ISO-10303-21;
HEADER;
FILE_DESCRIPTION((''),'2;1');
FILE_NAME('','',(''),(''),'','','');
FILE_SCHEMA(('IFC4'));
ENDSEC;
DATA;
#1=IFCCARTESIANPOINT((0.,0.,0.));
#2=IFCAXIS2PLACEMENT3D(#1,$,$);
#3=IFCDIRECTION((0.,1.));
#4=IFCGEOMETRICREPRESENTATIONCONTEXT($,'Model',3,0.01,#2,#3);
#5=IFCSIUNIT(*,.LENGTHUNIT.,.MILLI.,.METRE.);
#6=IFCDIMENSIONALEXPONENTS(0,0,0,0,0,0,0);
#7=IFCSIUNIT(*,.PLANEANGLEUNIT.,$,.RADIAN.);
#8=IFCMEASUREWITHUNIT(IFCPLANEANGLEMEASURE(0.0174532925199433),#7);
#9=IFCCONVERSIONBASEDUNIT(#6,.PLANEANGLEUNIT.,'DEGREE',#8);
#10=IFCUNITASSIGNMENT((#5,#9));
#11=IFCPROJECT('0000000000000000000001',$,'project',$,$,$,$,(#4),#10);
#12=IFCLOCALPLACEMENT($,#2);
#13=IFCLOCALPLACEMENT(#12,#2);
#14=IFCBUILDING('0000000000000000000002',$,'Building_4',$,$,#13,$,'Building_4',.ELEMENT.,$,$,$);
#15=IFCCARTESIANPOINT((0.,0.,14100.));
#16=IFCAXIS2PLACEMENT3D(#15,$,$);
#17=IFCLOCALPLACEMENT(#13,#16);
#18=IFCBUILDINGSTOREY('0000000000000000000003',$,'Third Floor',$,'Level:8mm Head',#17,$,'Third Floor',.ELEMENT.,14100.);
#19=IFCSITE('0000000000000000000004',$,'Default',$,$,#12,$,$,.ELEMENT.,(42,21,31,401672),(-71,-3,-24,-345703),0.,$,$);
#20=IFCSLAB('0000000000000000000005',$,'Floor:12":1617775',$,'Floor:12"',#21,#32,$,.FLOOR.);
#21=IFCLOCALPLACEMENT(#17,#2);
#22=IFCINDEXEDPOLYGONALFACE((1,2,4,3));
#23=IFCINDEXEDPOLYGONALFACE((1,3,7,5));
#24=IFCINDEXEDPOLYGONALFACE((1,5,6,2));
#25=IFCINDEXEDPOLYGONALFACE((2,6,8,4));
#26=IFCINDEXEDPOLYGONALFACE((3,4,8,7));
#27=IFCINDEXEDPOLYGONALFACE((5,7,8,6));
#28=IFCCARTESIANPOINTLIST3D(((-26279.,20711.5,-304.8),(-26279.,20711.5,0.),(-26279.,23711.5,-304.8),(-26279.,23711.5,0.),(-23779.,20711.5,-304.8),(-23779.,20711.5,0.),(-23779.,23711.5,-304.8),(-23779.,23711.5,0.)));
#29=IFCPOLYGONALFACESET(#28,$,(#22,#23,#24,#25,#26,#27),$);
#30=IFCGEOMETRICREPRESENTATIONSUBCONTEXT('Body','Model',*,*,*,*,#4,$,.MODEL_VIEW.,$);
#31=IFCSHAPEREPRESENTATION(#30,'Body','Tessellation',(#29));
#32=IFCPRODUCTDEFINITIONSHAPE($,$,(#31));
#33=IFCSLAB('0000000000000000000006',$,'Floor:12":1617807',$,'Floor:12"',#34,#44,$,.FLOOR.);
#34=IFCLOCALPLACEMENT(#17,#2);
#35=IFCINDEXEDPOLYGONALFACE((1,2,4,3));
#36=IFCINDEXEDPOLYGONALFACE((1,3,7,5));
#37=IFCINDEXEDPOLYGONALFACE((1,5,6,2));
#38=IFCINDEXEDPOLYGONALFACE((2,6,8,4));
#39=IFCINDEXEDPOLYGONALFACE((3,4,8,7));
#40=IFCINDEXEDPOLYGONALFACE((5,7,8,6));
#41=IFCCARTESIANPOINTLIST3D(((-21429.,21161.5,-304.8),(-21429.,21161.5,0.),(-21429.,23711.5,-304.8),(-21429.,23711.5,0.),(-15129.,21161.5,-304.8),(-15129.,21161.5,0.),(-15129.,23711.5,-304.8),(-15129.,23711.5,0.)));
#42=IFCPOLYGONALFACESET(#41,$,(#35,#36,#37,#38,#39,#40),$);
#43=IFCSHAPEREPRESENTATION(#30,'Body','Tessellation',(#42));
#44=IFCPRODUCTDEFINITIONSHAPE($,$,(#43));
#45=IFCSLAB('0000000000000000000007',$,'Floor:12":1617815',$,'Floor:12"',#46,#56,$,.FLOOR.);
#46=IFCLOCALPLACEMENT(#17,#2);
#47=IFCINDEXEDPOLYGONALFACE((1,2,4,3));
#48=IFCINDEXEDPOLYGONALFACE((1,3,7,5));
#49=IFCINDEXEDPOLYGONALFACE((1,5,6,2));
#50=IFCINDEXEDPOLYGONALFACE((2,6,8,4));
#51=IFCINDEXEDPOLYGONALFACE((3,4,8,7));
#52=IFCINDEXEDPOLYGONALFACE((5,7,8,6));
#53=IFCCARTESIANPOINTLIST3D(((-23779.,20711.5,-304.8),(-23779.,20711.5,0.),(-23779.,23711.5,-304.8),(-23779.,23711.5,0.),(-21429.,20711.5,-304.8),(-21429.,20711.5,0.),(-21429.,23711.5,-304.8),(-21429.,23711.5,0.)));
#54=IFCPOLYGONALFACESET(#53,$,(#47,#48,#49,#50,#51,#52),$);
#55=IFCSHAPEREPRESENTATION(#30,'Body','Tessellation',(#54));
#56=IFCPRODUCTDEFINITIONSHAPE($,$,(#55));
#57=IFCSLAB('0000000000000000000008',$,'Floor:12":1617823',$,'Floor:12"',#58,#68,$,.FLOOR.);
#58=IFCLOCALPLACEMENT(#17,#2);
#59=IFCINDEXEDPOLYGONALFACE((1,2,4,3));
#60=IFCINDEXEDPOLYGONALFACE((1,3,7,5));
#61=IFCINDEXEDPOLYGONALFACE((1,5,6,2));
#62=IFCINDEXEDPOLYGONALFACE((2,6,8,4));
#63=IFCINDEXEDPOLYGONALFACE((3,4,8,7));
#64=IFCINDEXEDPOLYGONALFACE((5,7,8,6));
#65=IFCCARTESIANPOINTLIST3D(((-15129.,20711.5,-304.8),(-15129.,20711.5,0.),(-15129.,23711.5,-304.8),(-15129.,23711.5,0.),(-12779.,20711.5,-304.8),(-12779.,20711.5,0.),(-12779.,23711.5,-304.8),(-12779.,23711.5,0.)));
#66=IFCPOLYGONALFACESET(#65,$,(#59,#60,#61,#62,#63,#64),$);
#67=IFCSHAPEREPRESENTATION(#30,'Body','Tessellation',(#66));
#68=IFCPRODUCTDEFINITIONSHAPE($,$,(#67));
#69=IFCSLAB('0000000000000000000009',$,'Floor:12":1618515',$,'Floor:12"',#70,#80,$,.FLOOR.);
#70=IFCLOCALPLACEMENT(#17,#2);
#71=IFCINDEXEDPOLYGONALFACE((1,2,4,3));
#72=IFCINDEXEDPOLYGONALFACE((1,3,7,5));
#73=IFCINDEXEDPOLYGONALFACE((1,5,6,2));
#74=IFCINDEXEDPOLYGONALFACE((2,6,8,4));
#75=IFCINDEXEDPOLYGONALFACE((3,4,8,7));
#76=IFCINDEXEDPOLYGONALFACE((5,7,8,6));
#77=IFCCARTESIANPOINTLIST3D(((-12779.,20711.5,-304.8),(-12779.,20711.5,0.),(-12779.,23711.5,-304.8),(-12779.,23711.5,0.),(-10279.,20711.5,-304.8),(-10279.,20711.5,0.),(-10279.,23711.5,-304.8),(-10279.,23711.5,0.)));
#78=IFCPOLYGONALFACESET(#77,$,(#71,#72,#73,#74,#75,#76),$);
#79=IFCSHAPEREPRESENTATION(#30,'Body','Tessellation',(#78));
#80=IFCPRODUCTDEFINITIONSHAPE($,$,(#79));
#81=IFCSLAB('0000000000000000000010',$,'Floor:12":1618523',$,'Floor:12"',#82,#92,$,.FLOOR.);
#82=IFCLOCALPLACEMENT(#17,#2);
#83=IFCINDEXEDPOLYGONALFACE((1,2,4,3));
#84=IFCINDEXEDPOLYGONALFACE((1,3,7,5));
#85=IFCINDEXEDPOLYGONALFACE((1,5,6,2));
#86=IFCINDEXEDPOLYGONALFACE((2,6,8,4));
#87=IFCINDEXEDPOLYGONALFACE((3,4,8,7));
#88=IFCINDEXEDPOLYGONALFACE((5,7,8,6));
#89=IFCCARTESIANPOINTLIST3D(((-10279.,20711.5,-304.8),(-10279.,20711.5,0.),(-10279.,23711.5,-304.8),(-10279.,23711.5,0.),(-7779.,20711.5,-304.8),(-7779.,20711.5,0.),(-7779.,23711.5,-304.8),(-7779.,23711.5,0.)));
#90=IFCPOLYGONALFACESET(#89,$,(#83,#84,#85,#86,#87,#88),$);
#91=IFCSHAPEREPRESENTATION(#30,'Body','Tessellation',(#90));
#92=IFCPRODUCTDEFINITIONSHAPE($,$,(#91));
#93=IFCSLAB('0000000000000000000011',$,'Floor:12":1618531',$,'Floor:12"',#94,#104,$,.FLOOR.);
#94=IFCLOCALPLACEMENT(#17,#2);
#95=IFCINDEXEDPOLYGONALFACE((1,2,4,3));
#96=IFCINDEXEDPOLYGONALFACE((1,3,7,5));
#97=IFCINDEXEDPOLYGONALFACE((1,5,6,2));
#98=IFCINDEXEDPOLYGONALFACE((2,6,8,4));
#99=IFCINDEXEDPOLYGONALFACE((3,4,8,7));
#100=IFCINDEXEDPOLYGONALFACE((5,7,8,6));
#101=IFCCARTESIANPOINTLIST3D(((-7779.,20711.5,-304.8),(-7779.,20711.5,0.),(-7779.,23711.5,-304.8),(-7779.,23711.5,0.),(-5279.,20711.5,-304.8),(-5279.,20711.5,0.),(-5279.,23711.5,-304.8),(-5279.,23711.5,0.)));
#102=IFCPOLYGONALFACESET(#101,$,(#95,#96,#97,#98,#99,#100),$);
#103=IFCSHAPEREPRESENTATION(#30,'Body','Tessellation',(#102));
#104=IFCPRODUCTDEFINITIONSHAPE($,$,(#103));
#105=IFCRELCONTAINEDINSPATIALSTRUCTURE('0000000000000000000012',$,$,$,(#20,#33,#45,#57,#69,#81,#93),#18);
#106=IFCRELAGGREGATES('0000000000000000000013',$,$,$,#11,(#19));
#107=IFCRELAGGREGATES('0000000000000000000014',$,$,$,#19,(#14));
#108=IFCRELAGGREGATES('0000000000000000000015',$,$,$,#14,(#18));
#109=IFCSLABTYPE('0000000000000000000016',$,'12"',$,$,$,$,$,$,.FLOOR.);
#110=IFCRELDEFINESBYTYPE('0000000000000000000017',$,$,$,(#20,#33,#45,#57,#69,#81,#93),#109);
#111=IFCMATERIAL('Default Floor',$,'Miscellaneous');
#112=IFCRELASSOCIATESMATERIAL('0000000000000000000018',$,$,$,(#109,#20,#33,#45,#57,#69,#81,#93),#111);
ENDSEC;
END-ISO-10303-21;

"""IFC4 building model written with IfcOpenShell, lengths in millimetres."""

from ifc_helpers import new_model, entity, si_unit, converted_unit, direction, frame, origin, place, context, subcontext, project, spatial, indexed_curve, outline, extrude, material, type_object, element, save


model = new_model("IFC4")

# Units and contexts
model_context = context("Model", 3, precision=0.01, world=origin(), true_north=direction((0.0, 1.0)))
body_context = subcontext(model_context, "Body", "Model", "MODEL_VIEW")
ifc_project = project(units=[si_unit("LENGTHUNIT", "METRE", prefix="MILLI"), converted_unit("PLANEANGLEUNIT", "DEGREE", entity("IfcPlaneAngleMeasure", 0.0174532925199433), si_unit("PLANEANGLEUNIT", "RADIAN"), dimensions=[0, 0, 0, 0, 0, 0, 0])], contexts=[model_context])

# Site, building, storey
site_placement = place(None, origin())
site = spatial("IfcSite", under=ifc_project, at=site_placement, Name="Default", CompositionType="ELEMENT", RefLatitude=(42, 21, 31, 401672), RefLongitude=(-71, -3, -24, -345703), RefElevation=0.0)
building_placement = place(site_placement, origin())
building = spatial("IfcBuilding", under=site, at=building_placement, Name="Building_4", LongName="Building_4", CompositionType="ELEMENT")
storey_placement = place(building_placement, frame((0.0, 0.0, 14100.0)))
storey = spatial("IfcBuildingStorey", under=building, at=storey_placement, Name="Third Floor", ObjectType="Level:8mm Head", LongName="Third Floor", CompositionType="ELEMENT", Elevation=14100.0)

# Slabs
ifc_material_1 = material(Name="Default Floor", Category="Miscellaneous")
slab_type = type_object("IfcSlabType", Name="12\"", PredefinedType="FLOOR", material=ifc_material_1)
slab_1_placement = place(storey_placement, origin())
element("IfcSlab", 1, at=slab_1_placement, inside=storey, type_object=slab_type, material=ifc_material_1, Name="Floor:12\":1617775", ObjectType="Floor:12\"", PredefinedType="FLOOR", context=body_context, shape_type="SweptSolid", body=[
    extrude(outline(indexed_curve([(-1500.0, -1250.0), (1500.0, -1250.0), (1500.0, 1250.0), (-1500.0, 1250.0), (-1500.0, -1250.0)], self_intersect=False)), frame((-25029.0, 22211.5, 0.0), z_axis=(0.0, 0.0, -1.0), x_axis=(0.0, 1.0, 0.0)), (0.0, 0.0, 1.0), 304.8),
])
slab_2_placement = place(storey_placement, origin())
element("IfcSlab", 2, at=slab_2_placement, inside=storey, type_object=slab_type, material=ifc_material_1, Name="Floor:12\":1617807", ObjectType="Floor:12\"", PredefinedType="FLOOR", context=body_context, shape_type="SweptSolid", body=[
    extrude(outline(indexed_curve([(-1275.0, -3150.0), (1275.0, -3150.0), (1275.0, 3150.0), (-1275.0, 3150.0), (-1275.0, -3150.0)], self_intersect=False)), frame((-18279.0, 22436.5, 0.0), z_axis=(0.0, 0.0, -1.0), x_axis=(0.0, 1.0, 0.0)), (0.0, 0.0, 1.0), 304.8),
])
slab_3_placement = place(storey_placement, origin())
element("IfcSlab", 3, at=slab_3_placement, inside=storey, type_object=slab_type, material=ifc_material_1, Name="Floor:12\":1617815", ObjectType="Floor:12\"", PredefinedType="FLOOR", context=body_context, shape_type="SweptSolid", body=[
    extrude(outline(indexed_curve([(-1500.0, -1175.0), (1500.0, -1175.0), (1500.0, 1175.0), (-1500.0, 1175.0), (-1500.0, -1175.0)], self_intersect=False)), frame((-22604.0, 22211.5, 0.0), z_axis=(0.0, 0.0, -1.0), x_axis=(0.0, 1.0, 0.0)), (0.0, 0.0, 1.0), 304.8),
])
slab_4_placement = place(storey_placement, origin())
element("IfcSlab", 4, at=slab_4_placement, inside=storey, type_object=slab_type, material=ifc_material_1, Name="Floor:12\":1617823", ObjectType="Floor:12\"", PredefinedType="FLOOR", context=body_context, shape_type="SweptSolid", body=[
    extrude(outline(indexed_curve([(-1500.0, -1175.0), (1500.0, -1175.0), (1500.0, 1175.0), (-1500.0, 1175.0), (-1500.0, -1175.0)], self_intersect=False)), frame((-13954.0, 22211.5, 0.0), z_axis=(0.0, 0.0, -1.0), x_axis=(0.0, 1.0, 0.0)), (0.0, 0.0, 1.0), 304.8),
])
slab_5_placement = place(storey_placement, origin())
element("IfcSlab", 5, at=slab_5_placement, inside=storey, type_object=slab_type, material=ifc_material_1, Name="Floor:12\":1618515", ObjectType="Floor:12\"", PredefinedType="FLOOR", context=body_context, shape_type="SweptSolid", body=[
    extrude(outline(indexed_curve([(-1500.0, -1250.0), (1500.0, -1250.0), (1500.0, 1250.0), (-1500.0, 1250.0), (-1500.0, -1250.0)], self_intersect=False)), frame((-11529.0, 22211.5, 0.0), z_axis=(0.0, 0.0, -1.0), x_axis=(0.0, 1.0, 0.0)), (0.0, 0.0, 1.0), 304.8),
])
slab_6_placement = place(storey_placement, origin())
element("IfcSlab", 6, at=slab_6_placement, inside=storey, type_object=slab_type, material=ifc_material_1, Name="Floor:12\":1618523", ObjectType="Floor:12\"", PredefinedType="FLOOR", context=body_context, shape_type="SweptSolid", body=[
    extrude(outline(indexed_curve([(-1500.0, -1250.0), (1500.0, -1250.0), (1500.0, 1250.0), (-1500.0, 1250.0), (-1500.0, -1250.0)], self_intersect=False)), frame((-9029.0, 22211.5, 0.0), z_axis=(0.0, 0.0, -1.0), x_axis=(0.0, 1.0, 0.0)), (0.0, 0.0, 1.0), 304.8),
])
slab_7_placement = place(storey_placement, origin())
element("IfcSlab", 7, at=slab_7_placement, inside=storey, type_object=slab_type, material=ifc_material_1, Name="Floor:12\":1618531", ObjectType="Floor:12\"", PredefinedType="FLOOR", context=body_context, shape_type="SweptSolid", body=[
    extrude(outline(indexed_curve([(-1500.0, -1250.0), (1500.0, -1250.0), (1500.0, 1250.0), (-1500.0, 1250.0), (-1500.0, -1250.0)], self_intersect=False)), frame((-6529.0, 22211.5, 0.0), z_axis=(0.0, 0.0, -1.0), x_axis=(0.0, 1.0, 0.0)), (0.0, 0.0, 1.0), 304.8),
])

save(model, "model.ifc")
